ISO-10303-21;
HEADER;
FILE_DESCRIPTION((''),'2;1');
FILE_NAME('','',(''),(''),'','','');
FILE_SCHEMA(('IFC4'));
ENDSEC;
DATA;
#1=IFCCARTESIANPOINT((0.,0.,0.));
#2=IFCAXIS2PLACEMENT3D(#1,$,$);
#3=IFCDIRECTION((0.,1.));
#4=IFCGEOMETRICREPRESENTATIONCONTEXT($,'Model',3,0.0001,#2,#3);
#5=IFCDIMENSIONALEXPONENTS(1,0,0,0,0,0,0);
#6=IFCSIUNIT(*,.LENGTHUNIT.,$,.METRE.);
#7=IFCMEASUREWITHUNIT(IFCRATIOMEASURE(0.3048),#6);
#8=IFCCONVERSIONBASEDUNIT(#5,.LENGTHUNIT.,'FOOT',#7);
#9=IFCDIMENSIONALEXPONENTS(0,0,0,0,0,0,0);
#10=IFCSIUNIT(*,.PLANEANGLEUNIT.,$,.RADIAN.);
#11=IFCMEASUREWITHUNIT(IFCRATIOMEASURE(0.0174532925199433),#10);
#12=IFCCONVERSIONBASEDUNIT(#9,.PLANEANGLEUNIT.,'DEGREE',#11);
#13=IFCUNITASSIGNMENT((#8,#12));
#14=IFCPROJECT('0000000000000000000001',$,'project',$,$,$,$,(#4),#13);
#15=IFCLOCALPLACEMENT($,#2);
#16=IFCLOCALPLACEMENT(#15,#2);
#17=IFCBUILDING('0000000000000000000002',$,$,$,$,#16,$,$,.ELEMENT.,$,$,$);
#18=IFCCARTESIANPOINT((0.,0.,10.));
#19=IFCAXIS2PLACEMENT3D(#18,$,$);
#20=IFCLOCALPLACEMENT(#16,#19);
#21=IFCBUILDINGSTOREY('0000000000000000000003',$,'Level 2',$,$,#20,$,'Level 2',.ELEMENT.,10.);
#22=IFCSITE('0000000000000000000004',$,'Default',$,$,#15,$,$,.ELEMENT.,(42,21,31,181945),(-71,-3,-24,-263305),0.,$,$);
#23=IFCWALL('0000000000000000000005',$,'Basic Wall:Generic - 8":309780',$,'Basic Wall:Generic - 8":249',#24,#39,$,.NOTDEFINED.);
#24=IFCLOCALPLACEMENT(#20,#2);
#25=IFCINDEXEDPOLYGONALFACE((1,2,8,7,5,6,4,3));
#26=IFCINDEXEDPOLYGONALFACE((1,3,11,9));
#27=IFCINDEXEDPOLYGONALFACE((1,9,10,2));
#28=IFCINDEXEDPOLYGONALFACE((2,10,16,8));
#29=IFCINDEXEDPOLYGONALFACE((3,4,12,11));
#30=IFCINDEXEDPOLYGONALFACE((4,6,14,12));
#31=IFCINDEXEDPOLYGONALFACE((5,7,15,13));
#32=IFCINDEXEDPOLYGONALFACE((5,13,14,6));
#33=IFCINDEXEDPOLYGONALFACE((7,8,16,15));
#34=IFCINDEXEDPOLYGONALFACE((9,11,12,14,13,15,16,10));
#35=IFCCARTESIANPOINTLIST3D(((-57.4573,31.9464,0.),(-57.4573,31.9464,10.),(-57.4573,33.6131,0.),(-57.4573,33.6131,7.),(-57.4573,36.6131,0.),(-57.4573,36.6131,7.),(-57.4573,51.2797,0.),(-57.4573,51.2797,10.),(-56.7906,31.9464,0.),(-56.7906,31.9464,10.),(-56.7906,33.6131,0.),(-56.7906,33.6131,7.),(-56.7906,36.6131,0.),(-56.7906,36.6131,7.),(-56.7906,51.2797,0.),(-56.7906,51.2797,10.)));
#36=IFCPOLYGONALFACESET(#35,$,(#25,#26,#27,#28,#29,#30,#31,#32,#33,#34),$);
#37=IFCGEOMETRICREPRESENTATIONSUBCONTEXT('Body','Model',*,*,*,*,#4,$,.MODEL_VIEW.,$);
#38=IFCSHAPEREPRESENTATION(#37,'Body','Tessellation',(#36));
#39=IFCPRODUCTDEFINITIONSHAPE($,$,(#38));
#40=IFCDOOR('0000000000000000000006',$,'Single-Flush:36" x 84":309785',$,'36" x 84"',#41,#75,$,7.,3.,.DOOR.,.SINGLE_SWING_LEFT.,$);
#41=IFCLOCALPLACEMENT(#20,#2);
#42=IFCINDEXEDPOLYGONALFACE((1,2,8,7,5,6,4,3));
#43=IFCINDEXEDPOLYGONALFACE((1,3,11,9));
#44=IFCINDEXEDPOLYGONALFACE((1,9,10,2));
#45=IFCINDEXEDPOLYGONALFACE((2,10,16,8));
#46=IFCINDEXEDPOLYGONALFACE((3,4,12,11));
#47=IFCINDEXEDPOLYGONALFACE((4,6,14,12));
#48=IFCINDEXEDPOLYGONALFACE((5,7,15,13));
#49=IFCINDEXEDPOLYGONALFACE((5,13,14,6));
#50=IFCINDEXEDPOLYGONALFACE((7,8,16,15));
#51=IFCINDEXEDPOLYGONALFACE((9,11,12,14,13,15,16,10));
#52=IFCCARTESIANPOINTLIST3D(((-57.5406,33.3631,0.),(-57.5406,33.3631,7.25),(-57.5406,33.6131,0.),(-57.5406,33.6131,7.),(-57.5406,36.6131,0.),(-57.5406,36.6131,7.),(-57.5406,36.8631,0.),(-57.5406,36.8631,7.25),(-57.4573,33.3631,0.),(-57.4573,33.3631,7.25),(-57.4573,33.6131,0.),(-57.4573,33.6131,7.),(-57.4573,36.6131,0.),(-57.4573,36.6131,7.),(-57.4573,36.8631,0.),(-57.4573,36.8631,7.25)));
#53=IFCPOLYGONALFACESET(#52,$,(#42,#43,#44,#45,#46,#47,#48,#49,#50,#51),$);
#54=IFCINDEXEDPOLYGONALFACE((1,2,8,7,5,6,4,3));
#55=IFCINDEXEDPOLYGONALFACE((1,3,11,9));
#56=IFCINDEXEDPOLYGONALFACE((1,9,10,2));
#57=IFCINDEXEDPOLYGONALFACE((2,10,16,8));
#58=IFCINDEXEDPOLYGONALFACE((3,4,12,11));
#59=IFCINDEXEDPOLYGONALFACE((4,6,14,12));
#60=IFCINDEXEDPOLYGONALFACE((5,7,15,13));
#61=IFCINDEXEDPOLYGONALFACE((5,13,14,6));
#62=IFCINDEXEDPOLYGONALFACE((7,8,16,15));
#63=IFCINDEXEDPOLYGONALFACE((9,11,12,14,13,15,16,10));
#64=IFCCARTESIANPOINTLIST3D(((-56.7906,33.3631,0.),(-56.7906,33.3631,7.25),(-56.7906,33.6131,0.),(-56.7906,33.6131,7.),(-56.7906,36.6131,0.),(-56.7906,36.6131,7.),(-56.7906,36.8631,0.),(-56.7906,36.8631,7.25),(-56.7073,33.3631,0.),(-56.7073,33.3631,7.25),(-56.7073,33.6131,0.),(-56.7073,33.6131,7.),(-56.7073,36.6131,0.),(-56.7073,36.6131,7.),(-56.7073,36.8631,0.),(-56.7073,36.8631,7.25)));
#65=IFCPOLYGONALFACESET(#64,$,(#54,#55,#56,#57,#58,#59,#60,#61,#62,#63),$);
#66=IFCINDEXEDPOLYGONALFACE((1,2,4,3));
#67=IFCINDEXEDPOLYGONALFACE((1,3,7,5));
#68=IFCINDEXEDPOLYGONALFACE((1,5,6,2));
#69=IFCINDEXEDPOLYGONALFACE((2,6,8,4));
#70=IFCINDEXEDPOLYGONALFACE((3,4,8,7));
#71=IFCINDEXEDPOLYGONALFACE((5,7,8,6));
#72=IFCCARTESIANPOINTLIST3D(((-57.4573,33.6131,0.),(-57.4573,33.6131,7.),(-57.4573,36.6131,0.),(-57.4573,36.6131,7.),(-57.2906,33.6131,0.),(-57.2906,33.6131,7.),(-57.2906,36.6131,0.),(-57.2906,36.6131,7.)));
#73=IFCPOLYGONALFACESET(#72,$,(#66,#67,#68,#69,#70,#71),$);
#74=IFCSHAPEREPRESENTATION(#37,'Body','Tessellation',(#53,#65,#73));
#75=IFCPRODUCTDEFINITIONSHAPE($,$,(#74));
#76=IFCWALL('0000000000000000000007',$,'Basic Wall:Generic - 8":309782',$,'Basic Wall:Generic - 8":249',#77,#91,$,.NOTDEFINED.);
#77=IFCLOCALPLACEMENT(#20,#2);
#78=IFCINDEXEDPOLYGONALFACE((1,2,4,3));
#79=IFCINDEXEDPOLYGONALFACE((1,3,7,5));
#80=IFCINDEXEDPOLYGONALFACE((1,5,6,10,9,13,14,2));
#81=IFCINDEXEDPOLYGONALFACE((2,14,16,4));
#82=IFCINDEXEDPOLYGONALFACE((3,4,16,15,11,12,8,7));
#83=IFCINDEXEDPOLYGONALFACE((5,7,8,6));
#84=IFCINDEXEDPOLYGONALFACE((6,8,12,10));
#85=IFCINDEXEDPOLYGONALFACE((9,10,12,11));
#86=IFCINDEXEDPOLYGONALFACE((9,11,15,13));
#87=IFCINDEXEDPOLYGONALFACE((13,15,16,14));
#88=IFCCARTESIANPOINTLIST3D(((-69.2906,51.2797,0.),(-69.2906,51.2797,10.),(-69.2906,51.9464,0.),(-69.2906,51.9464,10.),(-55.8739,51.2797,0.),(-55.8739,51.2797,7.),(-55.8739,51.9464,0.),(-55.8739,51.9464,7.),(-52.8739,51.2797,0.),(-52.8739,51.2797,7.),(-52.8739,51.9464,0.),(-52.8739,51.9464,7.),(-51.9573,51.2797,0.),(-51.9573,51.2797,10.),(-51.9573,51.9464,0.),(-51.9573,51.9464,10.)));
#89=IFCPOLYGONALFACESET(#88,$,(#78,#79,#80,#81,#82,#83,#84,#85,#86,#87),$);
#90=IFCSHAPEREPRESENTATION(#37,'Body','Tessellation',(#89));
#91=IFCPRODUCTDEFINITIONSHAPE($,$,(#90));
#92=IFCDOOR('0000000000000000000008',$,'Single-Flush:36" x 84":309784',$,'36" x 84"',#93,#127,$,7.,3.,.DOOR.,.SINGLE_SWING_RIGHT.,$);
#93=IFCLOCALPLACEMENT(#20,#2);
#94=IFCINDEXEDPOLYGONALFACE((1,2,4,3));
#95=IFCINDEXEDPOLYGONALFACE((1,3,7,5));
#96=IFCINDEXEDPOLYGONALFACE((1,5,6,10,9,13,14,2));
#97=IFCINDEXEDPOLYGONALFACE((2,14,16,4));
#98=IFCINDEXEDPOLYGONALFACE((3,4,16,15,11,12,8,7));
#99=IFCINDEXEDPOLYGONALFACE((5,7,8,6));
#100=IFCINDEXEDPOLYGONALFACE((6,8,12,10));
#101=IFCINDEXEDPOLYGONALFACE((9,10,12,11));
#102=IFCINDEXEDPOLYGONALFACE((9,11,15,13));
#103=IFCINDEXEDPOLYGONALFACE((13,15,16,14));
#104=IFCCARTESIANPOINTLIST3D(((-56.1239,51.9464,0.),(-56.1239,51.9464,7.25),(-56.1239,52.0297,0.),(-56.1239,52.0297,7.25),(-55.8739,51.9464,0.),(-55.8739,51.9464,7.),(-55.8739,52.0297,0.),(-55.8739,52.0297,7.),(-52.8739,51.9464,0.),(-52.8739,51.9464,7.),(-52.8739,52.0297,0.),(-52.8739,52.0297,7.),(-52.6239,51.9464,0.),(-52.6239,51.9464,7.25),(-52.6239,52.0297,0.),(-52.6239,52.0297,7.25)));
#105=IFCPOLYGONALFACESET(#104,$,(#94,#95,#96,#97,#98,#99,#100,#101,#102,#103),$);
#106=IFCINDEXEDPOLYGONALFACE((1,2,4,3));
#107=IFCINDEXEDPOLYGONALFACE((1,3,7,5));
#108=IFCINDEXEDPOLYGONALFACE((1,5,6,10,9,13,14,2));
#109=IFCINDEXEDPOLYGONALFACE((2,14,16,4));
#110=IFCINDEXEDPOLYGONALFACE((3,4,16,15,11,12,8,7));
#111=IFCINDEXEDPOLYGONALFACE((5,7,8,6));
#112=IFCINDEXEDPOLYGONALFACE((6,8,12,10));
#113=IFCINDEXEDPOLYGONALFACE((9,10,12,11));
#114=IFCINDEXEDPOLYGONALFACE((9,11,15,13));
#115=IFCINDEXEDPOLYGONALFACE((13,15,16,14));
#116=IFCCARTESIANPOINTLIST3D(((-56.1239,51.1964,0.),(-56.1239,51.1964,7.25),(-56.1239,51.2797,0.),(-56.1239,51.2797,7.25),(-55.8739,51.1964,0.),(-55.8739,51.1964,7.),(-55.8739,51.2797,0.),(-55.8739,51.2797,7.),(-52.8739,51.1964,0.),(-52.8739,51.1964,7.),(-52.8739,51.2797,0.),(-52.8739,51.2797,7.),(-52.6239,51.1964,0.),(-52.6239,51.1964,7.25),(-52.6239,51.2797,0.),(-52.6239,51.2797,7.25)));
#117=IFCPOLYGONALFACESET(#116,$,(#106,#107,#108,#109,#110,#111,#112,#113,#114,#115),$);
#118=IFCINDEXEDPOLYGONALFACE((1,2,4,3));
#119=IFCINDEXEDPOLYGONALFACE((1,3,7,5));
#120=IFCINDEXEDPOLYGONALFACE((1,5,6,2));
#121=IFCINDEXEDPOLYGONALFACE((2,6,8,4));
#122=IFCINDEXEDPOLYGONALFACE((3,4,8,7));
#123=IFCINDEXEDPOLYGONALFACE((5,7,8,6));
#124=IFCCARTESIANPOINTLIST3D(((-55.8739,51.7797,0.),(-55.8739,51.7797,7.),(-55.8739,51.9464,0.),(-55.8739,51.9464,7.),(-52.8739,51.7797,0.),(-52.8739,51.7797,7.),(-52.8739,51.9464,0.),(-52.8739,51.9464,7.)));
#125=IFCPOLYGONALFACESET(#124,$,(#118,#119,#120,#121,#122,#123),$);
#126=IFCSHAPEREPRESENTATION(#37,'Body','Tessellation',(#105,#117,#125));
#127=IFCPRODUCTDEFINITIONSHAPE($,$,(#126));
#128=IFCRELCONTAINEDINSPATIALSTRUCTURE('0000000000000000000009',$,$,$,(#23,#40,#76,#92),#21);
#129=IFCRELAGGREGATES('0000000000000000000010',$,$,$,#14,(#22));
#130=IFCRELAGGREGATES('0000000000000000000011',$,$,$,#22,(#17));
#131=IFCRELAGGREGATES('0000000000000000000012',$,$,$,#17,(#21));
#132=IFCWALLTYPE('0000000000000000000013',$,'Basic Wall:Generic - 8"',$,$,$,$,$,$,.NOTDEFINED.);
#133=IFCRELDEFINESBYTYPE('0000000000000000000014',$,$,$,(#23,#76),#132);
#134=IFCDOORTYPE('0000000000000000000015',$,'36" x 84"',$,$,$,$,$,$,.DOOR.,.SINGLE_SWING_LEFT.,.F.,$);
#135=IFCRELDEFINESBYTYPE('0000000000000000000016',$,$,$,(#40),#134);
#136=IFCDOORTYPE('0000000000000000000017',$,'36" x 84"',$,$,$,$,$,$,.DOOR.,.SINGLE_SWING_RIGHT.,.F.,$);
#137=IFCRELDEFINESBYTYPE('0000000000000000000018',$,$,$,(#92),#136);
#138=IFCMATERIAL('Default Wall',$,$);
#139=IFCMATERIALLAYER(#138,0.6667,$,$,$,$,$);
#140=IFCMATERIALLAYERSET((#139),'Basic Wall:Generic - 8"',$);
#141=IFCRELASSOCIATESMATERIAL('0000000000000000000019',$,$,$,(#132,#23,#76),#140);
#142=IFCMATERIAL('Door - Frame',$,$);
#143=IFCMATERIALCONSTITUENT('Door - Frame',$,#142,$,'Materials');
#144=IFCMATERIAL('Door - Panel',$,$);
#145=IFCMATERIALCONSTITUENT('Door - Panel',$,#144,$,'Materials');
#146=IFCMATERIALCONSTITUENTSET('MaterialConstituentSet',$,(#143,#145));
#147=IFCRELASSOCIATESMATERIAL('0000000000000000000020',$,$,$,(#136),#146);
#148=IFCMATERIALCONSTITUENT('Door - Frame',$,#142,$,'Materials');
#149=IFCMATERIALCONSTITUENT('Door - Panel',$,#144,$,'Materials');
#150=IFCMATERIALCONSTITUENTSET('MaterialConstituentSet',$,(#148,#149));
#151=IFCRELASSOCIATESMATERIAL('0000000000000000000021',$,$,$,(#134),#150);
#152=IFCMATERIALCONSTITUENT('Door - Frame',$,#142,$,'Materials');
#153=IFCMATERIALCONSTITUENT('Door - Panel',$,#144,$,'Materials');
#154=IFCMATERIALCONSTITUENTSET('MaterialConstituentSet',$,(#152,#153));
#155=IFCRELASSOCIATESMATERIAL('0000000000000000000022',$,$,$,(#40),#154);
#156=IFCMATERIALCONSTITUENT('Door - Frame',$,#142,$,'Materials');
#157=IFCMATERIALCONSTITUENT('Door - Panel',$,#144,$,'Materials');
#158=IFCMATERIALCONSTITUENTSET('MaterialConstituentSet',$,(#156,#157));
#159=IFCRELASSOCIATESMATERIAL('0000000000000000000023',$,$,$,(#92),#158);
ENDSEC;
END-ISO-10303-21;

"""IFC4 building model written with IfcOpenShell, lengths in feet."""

from ifc_helpers import new_model, entity, si_unit, converted_unit, direction, frame, frame_2d, origin, place, context, subcontext, project, spatial, polyline, rectangle, outline, extrude, source, transform, mapped, material, layer, layer_set, layer_usage, constituent, constituent_set, type_object, type_shapes, element, fill, save


model = new_model("IFC4")

# Units and contexts
model_context = context("Model", 3, precision=0.0001, world=origin(), true_north=direction((0.0, 1.0)))
body_context = subcontext(model_context, "Body", "Model", "MODEL_VIEW")
ifc_project = project(units=[converted_unit("LENGTHUNIT", "FOOT", entity("IfcRatioMeasure", 0.3048), si_unit("LENGTHUNIT", "METRE"), dimensions=[1, 0, 0, 0, 0, 0, 0]), converted_unit("PLANEANGLEUNIT", "DEGREE", entity("IfcRatioMeasure", 0.0174532925199433), si_unit("PLANEANGLEUNIT", "RADIAN"), dimensions=[0, 0, 0, 0, 0, 0, 0])], contexts=[model_context])

# Site, building, storey
site_placement = place(None, origin())
site = spatial("IfcSite", under=ifc_project, at=site_placement, Name="Default", CompositionType="ELEMENT", RefLatitude=(42, 21, 31, 181945), RefLongitude=(-71, -3, -24, -263305), RefElevation=0.0)
building_placement = place(site_placement, origin())
building = spatial("IfcBuilding", under=site, at=building_placement, CompositionType="ELEMENT")
storey_placement = place(building_placement, frame((0.0, 0.0, 10.0)))
storey = spatial("IfcBuildingStorey", under=building, at=storey_placement, Name="Level 2", LongName="Level 2", CompositionType="ELEMENT", Elevation=10.0)

# Shared definitions
ifc_material_1 = material(Name="Default Wall")
ifc_layer = layer(ifc_material_1, 0.6667)
ifc_layer_set = layer_set([ifc_layer], Name="Basic Wall:Generic - 8\"")
wall_type = type_object("IfcWallType", Name="Basic Wall:Generic - 8\"", PredefinedType="NOTDEFINED", material=ifc_layer_set)

# Shared definitions
ifc_material_2 = material(Name="Door - Frame")
ifc_material_3 = material(Name="Door - Panel")
ifc_constituent_1 = constituent(ifc_material_2, Name="Door - Frame", Category="Materials")
ifc_constituent_2 = constituent(ifc_material_3, Name="Door - Panel", Category="Materials")
ifc_constituent_set_1 = constituent_set(constituents=[ifc_constituent_1, ifc_constituent_2], Name="MaterialConstituentSet")
door_type_1 = type_object("IfcDoorType", Name="36\" x 84\"", OperationType="SINGLE_SWING_RIGHT", ParameterTakesPrecedence=False, PredefinedType="DOOR", material=ifc_constituent_set_1)
shared_shape_1 = source(origin(), body_context, "Body", "SweptSolid", [
    extrude(outline(polyline([(-1.75, -3.6875), (1.75, -3.6875), (1.75, 3.5625), (1.5, 3.5625), (1.5, -3.4375), (-1.5, -3.4375), (-1.5, 3.5625), (-1.75, 3.5625), (-1.75, -3.6875)])), frame((1.5, 0.6667, 3.5625), z_axis=(0.0, 1.0, 0.0), x_axis=(1.0, 0.0, 0.0)), (0.0, 0.0, 1.0), 0.0833),
    extrude(outline(polyline([(-3.6875, -1.75), (3.5625, -1.75), (3.5625, -1.5), (-3.4375, -1.5), (-3.4375, 1.5), (3.5625, 1.5), (3.5625, 1.75), (-3.6875, 1.75), (-3.6875, -1.75)])), frame((1.5, -0.0833, 3.5625), z_axis=(0.0, 1.0, 0.0), x_axis=(0.0, 0.0, -1.0)), (0.0, 0.0, 1.0), 0.0833),
    extrude(rectangle(XDim=0.1667, YDim=3.0, at=frame_2d((0.0, 0.0), x_axis=(1.0, 0.0))), frame((1.5, 0.5833, 0.0), z_axis=(0.0, 0.0, 1.0), x_axis=(0.0, 1.0, 0.0)), (0.0, 0.0, 1.0), 7.0),
])
type_shapes(door_type_1, [shared_shape_1])

# Walls, openings, doors
ifc_layer_usage_1 = layer_usage(ifc_layer_set, "AXIS2", "NEGATIVE", 0.3333)
wall_1_placement = place(storey_placement, frame((-57.1239, 31.9464, 0.0), z_axis=(0.0, 0.0, 1.0), x_axis=(0.0, 1.0, 0.0)))
wall_1 = element("IfcWall", 1, at=wall_1_placement, inside=storey, type_object=wall_type, material=ifc_layer_usage_1, Name="Basic Wall:Generic - 8\":309780", ObjectType="Basic Wall:Generic - 8\":249", PredefinedType="NOTDEFINED", context=body_context, shape_type="SweptSolid", body=[
    extrude(rectangle(XDim=19.3333, YDim=0.6667, at=frame_2d((9.6667, 0.0), x_axis=(-1.0, 0.0))), origin(), (0.0, 0.0, 1.0), 10.0),
])
opening_1_placement = place(wall_1_placement, frame((1.6667, -0.3333, 0.0)))
opening_1 = element("IfcOpeningElement", 2, at=opening_1_placement, cuts=wall_1, ObjectType="Opening", PredefinedType="OPENING", context=body_context, shape_type="SweptSolid", body=[
    extrude(rectangle(XDim=3.0, YDim=7.0, at=frame_2d((3.5, 1.5), x_axis=(0.0, -1.0))), frame((0.0, 0.0, 0.0), z_axis=(0.0, 1.0, 0.0), x_axis=(0.0, 0.0, 1.0)), (0.0, 0.0, 1.0), 0.6667),
])
ifc_constituent_3 = constituent(ifc_material_2, Name="Door - Frame", Category="Materials")
ifc_constituent_4 = constituent(ifc_material_3, Name="Door - Panel", Category="Materials")
ifc_constituent_set_2 = constituent_set(constituents=[ifc_constituent_3, ifc_constituent_4], Name="MaterialConstituentSet")
ifc_constituent_5 = constituent(ifc_material_2, Name="Door - Frame", Category="Materials")
ifc_constituent_6 = constituent(ifc_material_3, Name="Door - Panel", Category="Materials")
ifc_constituent_set_3 = constituent_set(constituents=[ifc_constituent_5, ifc_constituent_6], Name="MaterialConstituentSet")
door_type_2 = type_object("IfcDoorType", Name="36\" x 84\"", OperationType="SINGLE_SWING_LEFT", ParameterTakesPrecedence=False, PredefinedType="DOOR", material=ifc_constituent_set_3)
shared_shape_2 = source(origin(), body_context, "Body", "SweptSolid", [
    extrude(outline(polyline([(-1.75, -3.6875), (1.75, -3.6875), (1.75, 3.5625), (1.5, 3.5625), (1.5, -3.4375), (-1.5, -3.4375), (-1.5, 3.5625), (-1.75, 3.5625), (-1.75, -3.6875)])), frame((1.5, 0.75, 3.5625), z_axis=(0.0, -1.0, 0.0), x_axis=(-1.0, 0.0, 0.0)), (0.0, 0.0, 1.0), 0.0833),
    extrude(outline(polyline([(-3.6875, -1.75), (3.5625, -1.75), (3.5625, -1.5), (-3.4375, -1.5), (-3.4375, 1.5), (3.5625, 1.5), (3.5625, 1.75), (-3.6875, 1.75), (-3.6875, -1.75)])), frame((1.5, 0.0, 3.5625), z_axis=(0.0, -1.0, 0.0), x_axis=(0.0, 0.0, -1.0)), (0.0, 0.0, 1.0), 0.0833),
    extrude(rectangle(XDim=3.0, YDim=0.1667, at=frame_2d((0.0, 0.0), x_axis=(1.0, 0.0))), frame((1.5, 0.5833, 0.0)), (0.0, 0.0, 1.0), 7.0),
])
type_shapes(door_type_2, [shared_shape_2])
door_1_placement = place(opening_1_placement, origin())
door_1 = element("IfcDoor", 3, at=door_1_placement, inside=storey, type_object=door_type_2, material=ifc_constituent_set_2, Name="Single-Flush:36\" x 84\":309785", ObjectType="36\" x 84\"", OperationType="SINGLE_SWING_LEFT", OverallHeight=7.0, OverallWidth=3.0, PredefinedType="DOOR", context=body_context, shape_type="MappedRepresentation", body=[
    mapped(shared_shape_2, transform((0.0, 0.0, 0.0), scale=1.0)),
])
fill(opening_1, door_1)
ifc_layer_usage_2 = layer_usage(ifc_layer_set, "AXIS2", "NEGATIVE", 0.3333)
wall_2_placement = place(storey_placement, frame((-69.2906, 51.6131, 0.0)))
wall_2 = element("IfcWall", 4, at=wall_2_placement, inside=storey, type_object=wall_type, material=ifc_layer_usage_2, Name="Basic Wall:Generic - 8\":309782", ObjectType="Basic Wall:Generic - 8\":249", PredefinedType="NOTDEFINED", context=body_context, shape_type="SweptSolid", body=[
    extrude(rectangle(XDim=17.3333, YDim=0.6667, at=frame_2d((8.6667, 0.0), x_axis=(-1.0, 0.0))), origin(), (0.0, 0.0, 1.0), 10.0),
])
opening_2_placement = place(wall_2_placement, frame((13.4167, -0.3333, 0.0)))
opening_2 = element("IfcOpeningElement", 5, at=opening_2_placement, cuts=wall_2, ObjectType="Opening", PredefinedType="OPENING", context=body_context, shape_type="SweptSolid", body=[
    extrude(rectangle(XDim=3.0, YDim=7.0, at=frame_2d((3.5, 1.5), x_axis=(0.0, 1.0))), frame((0.0, 0.0, 0.0), z_axis=(0.0, 1.0, 0.0), x_axis=(0.0, 0.0, 1.0)), (0.0, 0.0, 1.0), 0.6667),
])
ifc_constituent_7 = constituent(ifc_material_2, Name="Door - Frame", Category="Materials")
ifc_constituent_8 = constituent(ifc_material_3, Name="Door - Panel", Category="Materials")
ifc_constituent_set_4 = constituent_set(constituents=[ifc_constituent_7, ifc_constituent_8], Name="MaterialConstituentSet")
door_2_placement = place(opening_2_placement, origin())
door_2 = element("IfcDoor", 6, at=door_2_placement, inside=storey, type_object=door_type_1, material=ifc_constituent_set_4, Name="Single-Flush:36\" x 84\":309784", ObjectType="36\" x 84\"", OperationType="SINGLE_SWING_RIGHT", OverallHeight=7.0, OverallWidth=3.0, PredefinedType="DOOR", context=body_context, shape_type="MappedRepresentation", body=[
    mapped(shared_shape_1, transform((0.0, 0.0, 0.0), scale=1.0)),
])
fill(opening_2, door_2)

save(model, "model.ifc")
